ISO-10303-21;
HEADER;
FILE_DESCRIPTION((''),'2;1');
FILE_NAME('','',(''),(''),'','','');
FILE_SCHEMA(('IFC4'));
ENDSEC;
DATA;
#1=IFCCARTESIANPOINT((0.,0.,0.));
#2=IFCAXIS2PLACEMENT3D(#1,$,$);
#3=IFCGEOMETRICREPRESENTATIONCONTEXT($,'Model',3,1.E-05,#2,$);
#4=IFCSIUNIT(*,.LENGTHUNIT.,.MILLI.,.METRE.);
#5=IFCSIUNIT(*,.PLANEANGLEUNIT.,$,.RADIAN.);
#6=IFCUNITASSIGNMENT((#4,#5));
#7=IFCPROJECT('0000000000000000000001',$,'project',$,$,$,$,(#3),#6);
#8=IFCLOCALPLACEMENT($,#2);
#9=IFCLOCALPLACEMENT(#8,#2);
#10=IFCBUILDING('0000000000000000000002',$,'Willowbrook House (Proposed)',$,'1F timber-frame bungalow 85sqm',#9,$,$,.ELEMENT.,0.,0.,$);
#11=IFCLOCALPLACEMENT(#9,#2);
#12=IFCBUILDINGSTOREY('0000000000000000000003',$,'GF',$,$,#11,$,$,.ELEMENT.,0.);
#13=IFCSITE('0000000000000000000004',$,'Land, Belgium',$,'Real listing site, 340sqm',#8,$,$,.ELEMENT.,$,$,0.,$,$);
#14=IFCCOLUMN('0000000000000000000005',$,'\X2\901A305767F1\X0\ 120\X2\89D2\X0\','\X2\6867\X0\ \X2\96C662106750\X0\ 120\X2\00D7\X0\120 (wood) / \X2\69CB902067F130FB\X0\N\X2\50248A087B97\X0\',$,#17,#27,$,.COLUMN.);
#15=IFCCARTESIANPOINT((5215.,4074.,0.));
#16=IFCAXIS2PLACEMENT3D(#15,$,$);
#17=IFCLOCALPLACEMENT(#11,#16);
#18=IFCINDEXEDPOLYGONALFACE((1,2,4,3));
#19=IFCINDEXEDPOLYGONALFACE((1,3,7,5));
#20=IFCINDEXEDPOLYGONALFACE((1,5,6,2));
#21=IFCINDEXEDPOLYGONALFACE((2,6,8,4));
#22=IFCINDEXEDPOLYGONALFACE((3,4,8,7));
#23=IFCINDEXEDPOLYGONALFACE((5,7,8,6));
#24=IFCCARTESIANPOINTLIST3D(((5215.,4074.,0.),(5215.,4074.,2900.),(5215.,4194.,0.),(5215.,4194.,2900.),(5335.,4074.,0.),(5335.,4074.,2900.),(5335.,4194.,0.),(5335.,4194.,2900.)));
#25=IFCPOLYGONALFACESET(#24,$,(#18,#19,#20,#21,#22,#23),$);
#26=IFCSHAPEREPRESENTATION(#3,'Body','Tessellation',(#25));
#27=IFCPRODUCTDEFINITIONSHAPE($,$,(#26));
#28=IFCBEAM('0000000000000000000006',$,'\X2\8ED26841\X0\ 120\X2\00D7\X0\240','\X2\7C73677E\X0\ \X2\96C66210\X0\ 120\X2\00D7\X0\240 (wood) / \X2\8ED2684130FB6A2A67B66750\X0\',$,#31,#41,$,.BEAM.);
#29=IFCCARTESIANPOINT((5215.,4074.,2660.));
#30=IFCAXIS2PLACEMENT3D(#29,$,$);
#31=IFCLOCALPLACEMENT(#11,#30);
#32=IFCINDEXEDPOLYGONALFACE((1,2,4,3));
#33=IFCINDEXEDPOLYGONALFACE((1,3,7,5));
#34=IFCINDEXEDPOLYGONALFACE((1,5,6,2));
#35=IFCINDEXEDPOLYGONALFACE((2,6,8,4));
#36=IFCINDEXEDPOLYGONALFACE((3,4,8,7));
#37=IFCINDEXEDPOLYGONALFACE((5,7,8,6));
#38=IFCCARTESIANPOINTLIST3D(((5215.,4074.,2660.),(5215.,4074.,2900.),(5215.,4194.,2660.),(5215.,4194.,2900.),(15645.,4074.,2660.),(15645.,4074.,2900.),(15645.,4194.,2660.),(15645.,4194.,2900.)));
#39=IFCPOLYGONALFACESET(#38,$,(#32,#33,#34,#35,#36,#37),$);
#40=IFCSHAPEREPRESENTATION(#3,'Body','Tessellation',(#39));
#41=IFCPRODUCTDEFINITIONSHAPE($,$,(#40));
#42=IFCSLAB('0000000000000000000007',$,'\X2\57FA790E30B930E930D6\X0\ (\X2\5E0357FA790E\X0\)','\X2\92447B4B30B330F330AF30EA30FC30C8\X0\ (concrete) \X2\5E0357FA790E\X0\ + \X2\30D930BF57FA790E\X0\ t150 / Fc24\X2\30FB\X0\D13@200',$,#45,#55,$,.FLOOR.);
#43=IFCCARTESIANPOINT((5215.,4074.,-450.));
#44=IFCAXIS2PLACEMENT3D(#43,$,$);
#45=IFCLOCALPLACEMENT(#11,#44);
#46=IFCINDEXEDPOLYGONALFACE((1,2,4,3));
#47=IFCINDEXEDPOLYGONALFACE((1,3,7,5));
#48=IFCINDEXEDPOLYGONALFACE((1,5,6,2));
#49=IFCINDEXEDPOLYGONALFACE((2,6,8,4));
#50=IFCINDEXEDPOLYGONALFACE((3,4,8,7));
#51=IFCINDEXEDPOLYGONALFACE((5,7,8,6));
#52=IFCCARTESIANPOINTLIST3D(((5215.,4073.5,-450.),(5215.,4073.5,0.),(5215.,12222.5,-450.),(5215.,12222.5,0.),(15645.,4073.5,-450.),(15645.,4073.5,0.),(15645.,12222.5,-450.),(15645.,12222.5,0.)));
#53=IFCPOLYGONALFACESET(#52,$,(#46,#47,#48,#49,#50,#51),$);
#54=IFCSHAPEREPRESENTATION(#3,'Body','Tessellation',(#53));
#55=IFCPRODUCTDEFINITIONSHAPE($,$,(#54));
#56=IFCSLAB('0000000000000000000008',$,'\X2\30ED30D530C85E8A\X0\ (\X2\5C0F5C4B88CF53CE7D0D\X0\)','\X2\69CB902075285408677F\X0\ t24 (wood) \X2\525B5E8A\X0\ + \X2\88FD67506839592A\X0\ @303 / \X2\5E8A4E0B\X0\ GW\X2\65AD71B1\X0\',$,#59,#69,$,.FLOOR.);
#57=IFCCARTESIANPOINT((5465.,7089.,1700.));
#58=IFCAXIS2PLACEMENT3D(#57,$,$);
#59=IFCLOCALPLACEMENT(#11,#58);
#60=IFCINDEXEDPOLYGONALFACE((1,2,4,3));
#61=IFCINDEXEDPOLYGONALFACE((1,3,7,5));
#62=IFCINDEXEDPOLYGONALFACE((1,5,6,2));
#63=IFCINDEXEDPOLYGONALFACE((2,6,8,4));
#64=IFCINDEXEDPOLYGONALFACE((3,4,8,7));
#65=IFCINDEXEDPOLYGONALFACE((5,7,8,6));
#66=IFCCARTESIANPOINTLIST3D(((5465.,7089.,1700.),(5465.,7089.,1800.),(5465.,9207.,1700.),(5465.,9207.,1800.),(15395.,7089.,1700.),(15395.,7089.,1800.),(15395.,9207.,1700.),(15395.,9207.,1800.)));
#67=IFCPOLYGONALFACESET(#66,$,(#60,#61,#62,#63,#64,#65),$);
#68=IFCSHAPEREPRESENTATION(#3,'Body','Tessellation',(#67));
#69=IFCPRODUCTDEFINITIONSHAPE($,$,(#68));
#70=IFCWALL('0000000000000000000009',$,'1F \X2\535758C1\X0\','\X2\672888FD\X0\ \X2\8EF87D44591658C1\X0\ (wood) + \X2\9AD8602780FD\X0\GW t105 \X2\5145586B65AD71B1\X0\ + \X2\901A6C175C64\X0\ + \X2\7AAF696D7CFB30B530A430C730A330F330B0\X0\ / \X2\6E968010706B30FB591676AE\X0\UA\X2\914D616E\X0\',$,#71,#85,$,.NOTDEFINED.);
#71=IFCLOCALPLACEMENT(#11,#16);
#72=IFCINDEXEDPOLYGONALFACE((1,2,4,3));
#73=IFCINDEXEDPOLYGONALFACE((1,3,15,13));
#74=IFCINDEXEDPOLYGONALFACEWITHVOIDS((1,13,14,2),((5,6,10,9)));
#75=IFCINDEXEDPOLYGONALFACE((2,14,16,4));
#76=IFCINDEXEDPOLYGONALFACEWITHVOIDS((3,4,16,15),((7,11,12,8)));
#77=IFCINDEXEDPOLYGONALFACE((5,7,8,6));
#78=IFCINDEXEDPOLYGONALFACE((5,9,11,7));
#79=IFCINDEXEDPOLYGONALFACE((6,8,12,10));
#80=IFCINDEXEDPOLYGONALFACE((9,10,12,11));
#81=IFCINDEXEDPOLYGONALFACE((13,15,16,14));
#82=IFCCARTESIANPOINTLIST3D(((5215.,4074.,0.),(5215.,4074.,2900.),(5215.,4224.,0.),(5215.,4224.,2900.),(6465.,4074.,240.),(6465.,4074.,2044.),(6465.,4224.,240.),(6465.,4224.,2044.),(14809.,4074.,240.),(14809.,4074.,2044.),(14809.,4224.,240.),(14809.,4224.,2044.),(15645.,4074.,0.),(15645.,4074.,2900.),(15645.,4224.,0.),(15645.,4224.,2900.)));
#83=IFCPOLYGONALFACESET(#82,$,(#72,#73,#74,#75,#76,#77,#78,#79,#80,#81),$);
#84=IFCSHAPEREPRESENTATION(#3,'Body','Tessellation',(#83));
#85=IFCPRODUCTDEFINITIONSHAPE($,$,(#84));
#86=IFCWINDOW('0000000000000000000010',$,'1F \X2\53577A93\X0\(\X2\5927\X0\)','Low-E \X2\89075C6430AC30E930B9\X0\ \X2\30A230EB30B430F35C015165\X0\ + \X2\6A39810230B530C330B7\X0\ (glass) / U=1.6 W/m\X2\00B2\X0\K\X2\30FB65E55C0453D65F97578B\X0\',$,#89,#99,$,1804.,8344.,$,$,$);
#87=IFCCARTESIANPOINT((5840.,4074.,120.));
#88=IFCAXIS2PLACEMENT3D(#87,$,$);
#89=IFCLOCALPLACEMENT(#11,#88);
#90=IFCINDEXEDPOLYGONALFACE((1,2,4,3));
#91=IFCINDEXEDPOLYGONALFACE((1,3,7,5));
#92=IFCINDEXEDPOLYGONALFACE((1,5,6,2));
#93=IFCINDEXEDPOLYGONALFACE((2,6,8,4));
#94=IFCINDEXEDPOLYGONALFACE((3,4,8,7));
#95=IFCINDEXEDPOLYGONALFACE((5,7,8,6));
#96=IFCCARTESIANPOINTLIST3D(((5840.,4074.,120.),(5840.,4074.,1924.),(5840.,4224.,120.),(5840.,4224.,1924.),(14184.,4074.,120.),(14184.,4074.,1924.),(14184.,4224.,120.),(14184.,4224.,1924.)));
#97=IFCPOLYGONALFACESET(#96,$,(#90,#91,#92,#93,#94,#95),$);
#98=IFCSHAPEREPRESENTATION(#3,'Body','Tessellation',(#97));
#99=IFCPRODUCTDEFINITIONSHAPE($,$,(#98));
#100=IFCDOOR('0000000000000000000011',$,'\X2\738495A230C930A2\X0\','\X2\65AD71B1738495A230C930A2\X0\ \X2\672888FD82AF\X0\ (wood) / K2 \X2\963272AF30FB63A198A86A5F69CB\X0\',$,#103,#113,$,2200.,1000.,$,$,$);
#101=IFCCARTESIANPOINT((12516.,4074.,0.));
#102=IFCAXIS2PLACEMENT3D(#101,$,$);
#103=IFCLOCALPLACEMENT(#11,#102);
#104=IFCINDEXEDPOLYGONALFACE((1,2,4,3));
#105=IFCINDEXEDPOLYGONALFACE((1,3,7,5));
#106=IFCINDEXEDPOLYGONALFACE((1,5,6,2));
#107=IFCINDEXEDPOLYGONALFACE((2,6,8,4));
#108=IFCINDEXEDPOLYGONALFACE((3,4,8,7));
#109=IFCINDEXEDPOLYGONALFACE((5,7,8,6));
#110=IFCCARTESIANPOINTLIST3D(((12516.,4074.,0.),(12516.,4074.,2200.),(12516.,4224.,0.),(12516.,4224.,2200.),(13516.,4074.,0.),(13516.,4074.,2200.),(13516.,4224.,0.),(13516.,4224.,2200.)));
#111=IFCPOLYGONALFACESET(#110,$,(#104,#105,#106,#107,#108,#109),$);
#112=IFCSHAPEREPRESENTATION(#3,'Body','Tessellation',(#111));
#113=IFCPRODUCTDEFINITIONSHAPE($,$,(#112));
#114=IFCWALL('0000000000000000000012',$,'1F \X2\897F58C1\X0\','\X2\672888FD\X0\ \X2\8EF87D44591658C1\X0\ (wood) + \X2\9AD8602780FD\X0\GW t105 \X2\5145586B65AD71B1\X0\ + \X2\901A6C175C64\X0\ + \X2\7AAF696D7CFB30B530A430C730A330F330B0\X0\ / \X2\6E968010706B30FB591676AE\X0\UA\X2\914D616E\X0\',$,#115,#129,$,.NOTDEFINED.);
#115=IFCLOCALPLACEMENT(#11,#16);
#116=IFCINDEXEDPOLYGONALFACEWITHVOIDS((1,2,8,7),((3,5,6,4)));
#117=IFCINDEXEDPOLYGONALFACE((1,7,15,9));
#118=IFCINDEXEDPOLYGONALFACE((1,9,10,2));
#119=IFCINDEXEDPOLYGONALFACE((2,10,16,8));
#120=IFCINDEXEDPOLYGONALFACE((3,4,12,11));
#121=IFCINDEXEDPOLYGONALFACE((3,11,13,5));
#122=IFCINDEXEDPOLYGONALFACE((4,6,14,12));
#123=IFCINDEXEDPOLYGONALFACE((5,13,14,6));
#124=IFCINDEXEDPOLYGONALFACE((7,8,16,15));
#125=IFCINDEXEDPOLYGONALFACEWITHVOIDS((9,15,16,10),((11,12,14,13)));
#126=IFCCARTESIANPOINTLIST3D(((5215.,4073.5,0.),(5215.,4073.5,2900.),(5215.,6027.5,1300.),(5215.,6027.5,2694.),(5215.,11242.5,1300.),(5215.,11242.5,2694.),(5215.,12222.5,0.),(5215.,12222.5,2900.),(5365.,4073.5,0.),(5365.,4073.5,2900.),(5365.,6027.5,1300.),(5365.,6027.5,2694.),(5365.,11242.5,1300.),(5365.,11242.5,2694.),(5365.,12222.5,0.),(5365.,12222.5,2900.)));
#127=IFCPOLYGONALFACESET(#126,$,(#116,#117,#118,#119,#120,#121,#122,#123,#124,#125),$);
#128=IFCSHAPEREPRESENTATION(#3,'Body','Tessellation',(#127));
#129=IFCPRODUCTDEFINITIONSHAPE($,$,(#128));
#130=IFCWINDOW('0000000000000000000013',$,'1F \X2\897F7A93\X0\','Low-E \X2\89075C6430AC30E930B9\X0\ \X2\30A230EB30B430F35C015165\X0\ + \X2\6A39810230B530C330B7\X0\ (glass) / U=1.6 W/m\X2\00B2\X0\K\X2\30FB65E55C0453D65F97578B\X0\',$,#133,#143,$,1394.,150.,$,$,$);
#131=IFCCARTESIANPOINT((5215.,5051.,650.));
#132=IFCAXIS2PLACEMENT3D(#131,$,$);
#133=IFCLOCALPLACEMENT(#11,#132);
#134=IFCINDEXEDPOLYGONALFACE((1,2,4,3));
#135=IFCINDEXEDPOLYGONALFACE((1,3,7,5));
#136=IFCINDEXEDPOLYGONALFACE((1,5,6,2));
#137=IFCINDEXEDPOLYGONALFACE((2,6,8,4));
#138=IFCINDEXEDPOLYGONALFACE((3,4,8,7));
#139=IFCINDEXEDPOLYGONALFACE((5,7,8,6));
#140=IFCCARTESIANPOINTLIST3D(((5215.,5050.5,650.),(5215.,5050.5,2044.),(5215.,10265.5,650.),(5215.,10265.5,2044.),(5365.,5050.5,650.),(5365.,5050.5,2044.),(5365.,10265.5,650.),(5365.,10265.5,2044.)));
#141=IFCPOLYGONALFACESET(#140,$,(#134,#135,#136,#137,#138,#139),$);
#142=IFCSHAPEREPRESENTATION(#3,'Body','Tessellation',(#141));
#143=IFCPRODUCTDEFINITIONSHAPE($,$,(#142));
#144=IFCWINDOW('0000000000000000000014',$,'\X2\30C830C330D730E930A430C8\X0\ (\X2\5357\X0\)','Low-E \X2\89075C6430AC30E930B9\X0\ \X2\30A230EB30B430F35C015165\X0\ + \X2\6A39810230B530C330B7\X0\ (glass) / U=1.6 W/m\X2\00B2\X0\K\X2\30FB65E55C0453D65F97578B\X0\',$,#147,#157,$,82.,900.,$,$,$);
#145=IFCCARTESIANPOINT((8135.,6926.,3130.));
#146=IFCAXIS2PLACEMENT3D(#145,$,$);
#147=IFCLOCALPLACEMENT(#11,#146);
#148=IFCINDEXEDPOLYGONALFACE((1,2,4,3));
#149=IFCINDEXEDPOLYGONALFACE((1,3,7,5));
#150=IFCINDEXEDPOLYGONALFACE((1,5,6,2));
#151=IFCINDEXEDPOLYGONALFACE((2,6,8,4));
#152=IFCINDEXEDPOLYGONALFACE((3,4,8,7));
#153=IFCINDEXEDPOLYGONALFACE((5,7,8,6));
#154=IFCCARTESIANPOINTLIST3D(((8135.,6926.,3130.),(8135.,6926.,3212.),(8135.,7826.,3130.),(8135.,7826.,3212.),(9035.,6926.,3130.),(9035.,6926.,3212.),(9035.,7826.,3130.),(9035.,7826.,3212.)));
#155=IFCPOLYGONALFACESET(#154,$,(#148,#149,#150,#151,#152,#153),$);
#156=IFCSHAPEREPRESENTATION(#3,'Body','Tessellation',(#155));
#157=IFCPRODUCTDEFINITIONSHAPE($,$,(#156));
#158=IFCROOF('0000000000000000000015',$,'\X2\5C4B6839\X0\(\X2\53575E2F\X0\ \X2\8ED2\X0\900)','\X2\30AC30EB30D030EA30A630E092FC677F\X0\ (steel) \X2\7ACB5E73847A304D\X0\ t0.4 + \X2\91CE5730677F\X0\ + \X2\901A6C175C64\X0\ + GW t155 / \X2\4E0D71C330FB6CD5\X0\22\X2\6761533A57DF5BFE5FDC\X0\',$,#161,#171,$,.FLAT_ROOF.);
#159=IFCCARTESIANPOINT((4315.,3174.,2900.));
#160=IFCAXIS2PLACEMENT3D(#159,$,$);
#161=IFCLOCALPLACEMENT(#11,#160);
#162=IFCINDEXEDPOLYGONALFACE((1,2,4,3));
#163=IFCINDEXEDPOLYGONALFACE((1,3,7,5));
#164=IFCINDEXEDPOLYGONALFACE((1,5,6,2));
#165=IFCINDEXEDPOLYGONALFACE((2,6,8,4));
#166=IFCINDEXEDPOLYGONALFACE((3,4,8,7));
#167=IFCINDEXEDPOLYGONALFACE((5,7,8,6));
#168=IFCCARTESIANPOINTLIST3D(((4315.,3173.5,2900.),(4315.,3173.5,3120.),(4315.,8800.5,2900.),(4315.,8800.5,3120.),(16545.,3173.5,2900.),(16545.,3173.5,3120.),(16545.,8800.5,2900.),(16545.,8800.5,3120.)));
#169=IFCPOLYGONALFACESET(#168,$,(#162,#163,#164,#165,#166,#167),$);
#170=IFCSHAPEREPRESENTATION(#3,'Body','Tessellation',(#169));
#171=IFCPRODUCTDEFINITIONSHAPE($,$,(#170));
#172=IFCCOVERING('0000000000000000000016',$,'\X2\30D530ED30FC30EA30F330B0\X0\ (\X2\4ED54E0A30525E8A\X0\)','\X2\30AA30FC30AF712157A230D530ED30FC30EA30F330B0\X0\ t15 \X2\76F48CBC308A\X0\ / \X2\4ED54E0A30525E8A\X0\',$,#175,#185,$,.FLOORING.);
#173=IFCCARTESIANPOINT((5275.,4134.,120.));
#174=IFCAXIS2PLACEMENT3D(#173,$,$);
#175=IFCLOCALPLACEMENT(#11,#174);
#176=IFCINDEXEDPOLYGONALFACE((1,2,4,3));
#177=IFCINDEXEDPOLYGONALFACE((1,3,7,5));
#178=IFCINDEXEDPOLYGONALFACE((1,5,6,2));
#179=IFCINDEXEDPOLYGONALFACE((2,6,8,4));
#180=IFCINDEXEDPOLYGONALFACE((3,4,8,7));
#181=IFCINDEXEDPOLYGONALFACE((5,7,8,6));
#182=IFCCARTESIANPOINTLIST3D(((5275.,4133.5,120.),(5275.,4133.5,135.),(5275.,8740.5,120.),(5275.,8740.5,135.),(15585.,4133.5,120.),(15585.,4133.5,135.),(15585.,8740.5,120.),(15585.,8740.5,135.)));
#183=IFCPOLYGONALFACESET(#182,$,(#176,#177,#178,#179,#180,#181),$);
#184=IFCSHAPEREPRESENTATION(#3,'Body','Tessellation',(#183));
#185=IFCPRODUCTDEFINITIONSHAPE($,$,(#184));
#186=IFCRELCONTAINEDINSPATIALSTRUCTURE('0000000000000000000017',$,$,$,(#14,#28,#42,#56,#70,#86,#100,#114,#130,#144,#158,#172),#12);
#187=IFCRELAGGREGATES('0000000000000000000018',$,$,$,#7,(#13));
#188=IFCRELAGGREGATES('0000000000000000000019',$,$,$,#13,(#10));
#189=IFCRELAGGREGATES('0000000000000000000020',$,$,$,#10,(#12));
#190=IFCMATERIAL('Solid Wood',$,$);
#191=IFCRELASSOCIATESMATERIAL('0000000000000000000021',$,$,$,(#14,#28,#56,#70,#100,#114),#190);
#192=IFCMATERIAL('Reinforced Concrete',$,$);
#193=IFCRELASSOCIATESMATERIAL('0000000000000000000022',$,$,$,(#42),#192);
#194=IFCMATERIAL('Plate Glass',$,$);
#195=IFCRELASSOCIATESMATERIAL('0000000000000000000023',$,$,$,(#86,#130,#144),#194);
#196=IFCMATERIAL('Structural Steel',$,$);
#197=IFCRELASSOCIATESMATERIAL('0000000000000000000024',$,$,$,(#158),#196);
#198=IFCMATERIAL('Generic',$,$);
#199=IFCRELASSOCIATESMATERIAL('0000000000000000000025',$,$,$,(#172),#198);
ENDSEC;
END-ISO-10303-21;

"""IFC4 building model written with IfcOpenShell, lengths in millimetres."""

from ifc_helpers import new_model, si_unit, frame, frame_2d, origin, place, context, project, spatial, rectangle, extrude, material, element, fill, save


model = new_model("IFC4")

# Units and contexts
model_context = context("Model", 3, precision=1e-05, world=origin())
ifc_project = project(units=[si_unit("LENGTHUNIT", "METRE", prefix="MILLI"), si_unit("PLANEANGLEUNIT", "RADIAN")], contexts=[model_context])

# Site, building, storey
site_placement = place(None, origin())
site = spatial("IfcSite", under=ifc_project, at=site_placement, Name="Land, Belgium", ObjectType="Real listing site, 340sqm", CompositionType="ELEMENT", RefElevation=0.0)
building_placement = place(site_placement, origin())
building = spatial("IfcBuilding", under=site, at=building_placement, Name="Willowbrook House (Proposed)", ObjectType="1F timber-frame bungalow 85sqm", CompositionType="ELEMENT", ElevationOfRefHeight=0.0, ElevationOfTerrain=0.0)
storey_placement = place(building_placement, origin())
storey = spatial("IfcBuildingStorey", under=building, at=storey_placement, Name="GF", CompositionType="ELEMENT", Elevation=0.0)

# Column
ifc_material_1 = material(Name="Solid Wood")
column_1_placement = place(storey_placement, frame((5215.0, 4074.0, 0.0)))
element("IfcColumn", 1, at=column_1_placement, inside=storey, material=ifc_material_1, Name="通し柱 120角", Description="桧 集成材 120×120 (wood) / 構造柱・N値計算", PredefinedType="COLUMN", context=model_context, shape_type="SweptSolid", body=[
    extrude(rectangle(XDim=120.0, YDim=120.0, at=frame_2d((60.0, 60.0))), frame((5215.0, 4074.0, 0.0)), (0.0, 0.0, 1.0), 2900.0),
])

# Beam
beam_1_placement = place(storey_placement, frame((5215.0, 4074.0, 2660.0)))
element("IfcBeam", 2, at=beam_1_placement, inside=storey, material=ifc_material_1, Name="軒桁 120×240", Description="米松 集成 120×240 (wood) / 軒桁・横架材", PredefinedType="BEAM", context=model_context, shape_type="SweptSolid", body=[
    extrude(rectangle(XDim=10430.0, YDim=120.0, at=frame_2d((5215.0, 60.0))), frame((5215.0, 4074.0, 2660.0)), (0.0, 0.0, 1.0), 240.0),
])

# Slabs
ifc_material_2 = material(Name="Reinforced Concrete")
slab_1_placement = place(storey_placement, frame((5215.0, 4074.0, -450.0)))
element("IfcSlab", 3, at=slab_1_placement, inside=storey, material=ifc_material_2, Name="基礎スラブ (布基礎)", Description="鉄筋コンクリート (concrete) 布基礎 + ベタ基礎 t150 / Fc24・D13@200", PredefinedType="FLOOR", context=model_context, shape_type="SweptSolid", body=[
    extrude(rectangle(XDim=10430.0, YDim=8149.0, at=frame_2d((5215.0, 4074.0))), frame((5215.0, 4074.0, -450.0)), (0.0, 0.0, 1.0), 450.0),
])
slab_2_placement = place(storey_placement, frame((5465.0, 7089.0, 1700.0)))
element("IfcSlab", 4, at=slab_2_placement, inside=storey, material=ifc_material_1, Name="ロフト床 (小屋裏収納)", Description="構造用合板 t24 (wood) 剛床 + 製材根太 @303 / 床下 GW断熱", PredefinedType="FLOOR", context=model_context, shape_type="SweptSolid", body=[
    extrude(rectangle(XDim=9930.0, YDim=2118.0, at=frame_2d((4965.0, 1059.0))), frame((5465.0, 7089.0, 1700.0)), (0.0, 0.0, 1.0), 100.0),
])

# Wall, openings, window, door
wall_1_placement = place(storey_placement, frame((5215.0, 4074.0, 0.0)))
wall_1 = element("IfcWall", 5, at=wall_1_placement, inside=storey, material=ifc_material_1, Name="1F 南壁", Description="木製 軸組外壁 (wood) + 高性能GW t105 充填断熱 + 通気層 + 窯業系サイディング / 準耐火・外皮UA配慮", PredefinedType="NOTDEFINED", context=model_context, shape_type="SweptSolid", body=[
    extrude(rectangle(XDim=10430.0, YDim=150.0, at=frame_2d((5215.0, 75.0))), frame((5215.0, 4074.0, 0.0)), (0.0, 0.0, 1.0), 2900.0),
])
opening_1_placement = place(storey_placement, frame((5840.0, 4074.0, 120.0)))
opening_1 = element("IfcOpeningElement", 6, at=opening_1_placement, cuts=wall_1, PredefinedType="NOTDEFINED", context=model_context, shape_type="SweptSolid", body=[
    extrude(rectangle(XDim=8344.0, YDim=150.0, at=frame_2d((4172.0, 75.0))), frame((5840.0, 4074.0, 120.0)), (0.0, 0.0, 1.0), 1804.0),
])
opening_2_placement = place(storey_placement, frame((12516.0, 4074.0, 0.0)))
opening_2 = element("IfcOpeningElement", 7, at=opening_2_placement, cuts=wall_1, PredefinedType="NOTDEFINED", context=model_context, shape_type="SweptSolid", body=[
    extrude(rectangle(XDim=1000.0, YDim=150.0, at=frame_2d((500.0, 75.0))), frame((12516.0, 4074.0, 0.0)), (0.0, 0.0, 1.0), 2200.0),
])
ifc_material_3 = material(Name="Plate Glass")
window_1_placement = place(storey_placement, frame((5840.0, 4074.0, 120.0)))
window_1 = element("IfcWindow", 8, at=window_1_placement, inside=storey, material=ifc_material_3, Name="1F 南窓(大)", Description="Low-E 複層ガラス アルゴン封入 + 樹脂サッシ (glass) / U=1.6 W/m²K・日射取得型", OverallHeight=1804.0, OverallWidth=8344.0, context=model_context, shape_type="SweptSolid", body=[
    extrude(rectangle(XDim=8344.0, YDim=150.0, at=frame_2d((4172.0, 75.0))), frame((5840.0, 4074.0, 120.0)), (0.0, 0.0, 1.0), 1804.0),
])
fill(opening_1, window_1)
door_placement = place(storey_placement, frame((12516.0, 4074.0, 0.0)))
door = element("IfcDoor", 9, at=door_placement, inside=storey, material=ifc_material_1, Name="玄関ドア", Description="断熱玄関ドア 木製芯 (wood) / K2 防犯・採風機構", OverallHeight=2200.0, OverallWidth=1000.0, context=model_context, shape_type="SweptSolid", body=[
    extrude(rectangle(XDim=1000.0, YDim=150.0, at=frame_2d((500.0, 75.0))), frame((12516.0, 4074.0, 0.0)), (0.0, 0.0, 1.0), 2200.0),
])
fill(opening_2, door)

# Wall, opening, window
wall_2_placement = place(storey_placement, frame((5215.0, 4074.0, 0.0)))
wall_2 = element("IfcWall", 10, at=wall_2_placement, inside=storey, material=ifc_material_1, Name="1F 西壁", Description="木製 軸組外壁 (wood) + 高性能GW t105 充填断熱 + 通気層 + 窯業系サイディング / 準耐火・外皮UA配慮", PredefinedType="NOTDEFINED", context=model_context, shape_type="SweptSolid", body=[
    extrude(rectangle(XDim=150.0, YDim=8149.0, at=frame_2d((75.0, 4074.0))), frame((5215.0, 4074.0, 0.0)), (0.0, 0.0, 1.0), 2900.0),
])
opening_3_placement = place(storey_placement, frame((5215.0, 5051.0, 650.0)))
opening_3 = element("IfcOpeningElement", 11, at=opening_3_placement, cuts=wall_2, PredefinedType="NOTDEFINED", context=model_context, shape_type="SweptSolid", body=[
    extrude(rectangle(XDim=150.0, YDim=5215.0, at=frame_2d((75.0, 2607.0))), frame((5215.0, 5051.0, 650.0)), (0.0, 0.0, 1.0), 1394.0),
])
window_2_placement = place(storey_placement, frame((5215.0, 5051.0, 650.0)))
window_2 = element("IfcWindow", 12, at=window_2_placement, inside=storey, material=ifc_material_3, Name="1F 西窓", Description="Low-E 複層ガラス アルゴン封入 + 樹脂サッシ (glass) / U=1.6 W/m²K・日射取得型", OverallHeight=1394.0, OverallWidth=150.0, context=model_context, shape_type="SweptSolid", body=[
    extrude(rectangle(XDim=150.0, YDim=5215.0, at=frame_2d((75.0, 2607.0))), frame((5215.0, 5051.0, 650.0)), (0.0, 0.0, 1.0), 1394.0),
])
fill(opening_3, window_2)

# Window
window_3_placement = place(storey_placement, frame((8135.0, 6926.0, 3130.0)))
element("IfcWindow", 13, at=window_3_placement, inside=storey, material=ifc_material_3, Name="トップライト (南)", Description="Low-E 複層ガラス アルゴン封入 + 樹脂サッシ (glass) / U=1.6 W/m²K・日射取得型", OverallHeight=82.0, OverallWidth=900.0, context=model_context, shape_type="SweptSolid", body=[
    extrude(rectangle(XDim=900.0, YDim=900.0, at=frame_2d((450.0, 450.0))), frame((8135.0, 6926.0, 3130.0)), (0.0, 0.0, 1.0), 82.0),
])

# Roof
ifc_material_4 = material(Name="Structural Steel")
roof_placement = place(storey_placement, frame((4315.0, 3174.0, 2900.0)))
element("IfcRoof", 14, at=roof_placement, inside=storey, material=ifc_material_4, Name="屋根(南帯 軒900)", Description="ガルバリウム鋼板 (steel) 立平葺き t0.4 + 野地板 + 通気層 + GW t155 / 不燃・法22条区域対応", PredefinedType="FLAT_ROOF", context=model_context, shape_type="SweptSolid", body=[
    extrude(rectangle(XDim=12230.0, YDim=5627.0, at=frame_2d((6115.0, 2813.0))), frame((4315.0, 3174.0, 2900.0)), (0.0, 0.0, 1.0), 220.0),
])

# Covering
ifc_material_5 = material(Name="Generic")
covering_1_placement = place(storey_placement, frame((5275.0, 4134.0, 120.0)))
element("IfcCovering", 15, at=covering_1_placement, inside=storey, material=ifc_material_5, Name="フローリング (仕上げ床)", Description="オーク無垢フローリング t15 直貼り / 仕上げ床", PredefinedType="FLOORING", context=model_context, shape_type="SweptSolid", body=[
    extrude(rectangle(XDim=10310.0, YDim=4607.0, at=frame_2d((5155.0, 2303.0))), frame((5275.0, 4134.0, 120.0)), (0.0, 0.0, 1.0), 15.0),
])

save(model, "model.ifc")
